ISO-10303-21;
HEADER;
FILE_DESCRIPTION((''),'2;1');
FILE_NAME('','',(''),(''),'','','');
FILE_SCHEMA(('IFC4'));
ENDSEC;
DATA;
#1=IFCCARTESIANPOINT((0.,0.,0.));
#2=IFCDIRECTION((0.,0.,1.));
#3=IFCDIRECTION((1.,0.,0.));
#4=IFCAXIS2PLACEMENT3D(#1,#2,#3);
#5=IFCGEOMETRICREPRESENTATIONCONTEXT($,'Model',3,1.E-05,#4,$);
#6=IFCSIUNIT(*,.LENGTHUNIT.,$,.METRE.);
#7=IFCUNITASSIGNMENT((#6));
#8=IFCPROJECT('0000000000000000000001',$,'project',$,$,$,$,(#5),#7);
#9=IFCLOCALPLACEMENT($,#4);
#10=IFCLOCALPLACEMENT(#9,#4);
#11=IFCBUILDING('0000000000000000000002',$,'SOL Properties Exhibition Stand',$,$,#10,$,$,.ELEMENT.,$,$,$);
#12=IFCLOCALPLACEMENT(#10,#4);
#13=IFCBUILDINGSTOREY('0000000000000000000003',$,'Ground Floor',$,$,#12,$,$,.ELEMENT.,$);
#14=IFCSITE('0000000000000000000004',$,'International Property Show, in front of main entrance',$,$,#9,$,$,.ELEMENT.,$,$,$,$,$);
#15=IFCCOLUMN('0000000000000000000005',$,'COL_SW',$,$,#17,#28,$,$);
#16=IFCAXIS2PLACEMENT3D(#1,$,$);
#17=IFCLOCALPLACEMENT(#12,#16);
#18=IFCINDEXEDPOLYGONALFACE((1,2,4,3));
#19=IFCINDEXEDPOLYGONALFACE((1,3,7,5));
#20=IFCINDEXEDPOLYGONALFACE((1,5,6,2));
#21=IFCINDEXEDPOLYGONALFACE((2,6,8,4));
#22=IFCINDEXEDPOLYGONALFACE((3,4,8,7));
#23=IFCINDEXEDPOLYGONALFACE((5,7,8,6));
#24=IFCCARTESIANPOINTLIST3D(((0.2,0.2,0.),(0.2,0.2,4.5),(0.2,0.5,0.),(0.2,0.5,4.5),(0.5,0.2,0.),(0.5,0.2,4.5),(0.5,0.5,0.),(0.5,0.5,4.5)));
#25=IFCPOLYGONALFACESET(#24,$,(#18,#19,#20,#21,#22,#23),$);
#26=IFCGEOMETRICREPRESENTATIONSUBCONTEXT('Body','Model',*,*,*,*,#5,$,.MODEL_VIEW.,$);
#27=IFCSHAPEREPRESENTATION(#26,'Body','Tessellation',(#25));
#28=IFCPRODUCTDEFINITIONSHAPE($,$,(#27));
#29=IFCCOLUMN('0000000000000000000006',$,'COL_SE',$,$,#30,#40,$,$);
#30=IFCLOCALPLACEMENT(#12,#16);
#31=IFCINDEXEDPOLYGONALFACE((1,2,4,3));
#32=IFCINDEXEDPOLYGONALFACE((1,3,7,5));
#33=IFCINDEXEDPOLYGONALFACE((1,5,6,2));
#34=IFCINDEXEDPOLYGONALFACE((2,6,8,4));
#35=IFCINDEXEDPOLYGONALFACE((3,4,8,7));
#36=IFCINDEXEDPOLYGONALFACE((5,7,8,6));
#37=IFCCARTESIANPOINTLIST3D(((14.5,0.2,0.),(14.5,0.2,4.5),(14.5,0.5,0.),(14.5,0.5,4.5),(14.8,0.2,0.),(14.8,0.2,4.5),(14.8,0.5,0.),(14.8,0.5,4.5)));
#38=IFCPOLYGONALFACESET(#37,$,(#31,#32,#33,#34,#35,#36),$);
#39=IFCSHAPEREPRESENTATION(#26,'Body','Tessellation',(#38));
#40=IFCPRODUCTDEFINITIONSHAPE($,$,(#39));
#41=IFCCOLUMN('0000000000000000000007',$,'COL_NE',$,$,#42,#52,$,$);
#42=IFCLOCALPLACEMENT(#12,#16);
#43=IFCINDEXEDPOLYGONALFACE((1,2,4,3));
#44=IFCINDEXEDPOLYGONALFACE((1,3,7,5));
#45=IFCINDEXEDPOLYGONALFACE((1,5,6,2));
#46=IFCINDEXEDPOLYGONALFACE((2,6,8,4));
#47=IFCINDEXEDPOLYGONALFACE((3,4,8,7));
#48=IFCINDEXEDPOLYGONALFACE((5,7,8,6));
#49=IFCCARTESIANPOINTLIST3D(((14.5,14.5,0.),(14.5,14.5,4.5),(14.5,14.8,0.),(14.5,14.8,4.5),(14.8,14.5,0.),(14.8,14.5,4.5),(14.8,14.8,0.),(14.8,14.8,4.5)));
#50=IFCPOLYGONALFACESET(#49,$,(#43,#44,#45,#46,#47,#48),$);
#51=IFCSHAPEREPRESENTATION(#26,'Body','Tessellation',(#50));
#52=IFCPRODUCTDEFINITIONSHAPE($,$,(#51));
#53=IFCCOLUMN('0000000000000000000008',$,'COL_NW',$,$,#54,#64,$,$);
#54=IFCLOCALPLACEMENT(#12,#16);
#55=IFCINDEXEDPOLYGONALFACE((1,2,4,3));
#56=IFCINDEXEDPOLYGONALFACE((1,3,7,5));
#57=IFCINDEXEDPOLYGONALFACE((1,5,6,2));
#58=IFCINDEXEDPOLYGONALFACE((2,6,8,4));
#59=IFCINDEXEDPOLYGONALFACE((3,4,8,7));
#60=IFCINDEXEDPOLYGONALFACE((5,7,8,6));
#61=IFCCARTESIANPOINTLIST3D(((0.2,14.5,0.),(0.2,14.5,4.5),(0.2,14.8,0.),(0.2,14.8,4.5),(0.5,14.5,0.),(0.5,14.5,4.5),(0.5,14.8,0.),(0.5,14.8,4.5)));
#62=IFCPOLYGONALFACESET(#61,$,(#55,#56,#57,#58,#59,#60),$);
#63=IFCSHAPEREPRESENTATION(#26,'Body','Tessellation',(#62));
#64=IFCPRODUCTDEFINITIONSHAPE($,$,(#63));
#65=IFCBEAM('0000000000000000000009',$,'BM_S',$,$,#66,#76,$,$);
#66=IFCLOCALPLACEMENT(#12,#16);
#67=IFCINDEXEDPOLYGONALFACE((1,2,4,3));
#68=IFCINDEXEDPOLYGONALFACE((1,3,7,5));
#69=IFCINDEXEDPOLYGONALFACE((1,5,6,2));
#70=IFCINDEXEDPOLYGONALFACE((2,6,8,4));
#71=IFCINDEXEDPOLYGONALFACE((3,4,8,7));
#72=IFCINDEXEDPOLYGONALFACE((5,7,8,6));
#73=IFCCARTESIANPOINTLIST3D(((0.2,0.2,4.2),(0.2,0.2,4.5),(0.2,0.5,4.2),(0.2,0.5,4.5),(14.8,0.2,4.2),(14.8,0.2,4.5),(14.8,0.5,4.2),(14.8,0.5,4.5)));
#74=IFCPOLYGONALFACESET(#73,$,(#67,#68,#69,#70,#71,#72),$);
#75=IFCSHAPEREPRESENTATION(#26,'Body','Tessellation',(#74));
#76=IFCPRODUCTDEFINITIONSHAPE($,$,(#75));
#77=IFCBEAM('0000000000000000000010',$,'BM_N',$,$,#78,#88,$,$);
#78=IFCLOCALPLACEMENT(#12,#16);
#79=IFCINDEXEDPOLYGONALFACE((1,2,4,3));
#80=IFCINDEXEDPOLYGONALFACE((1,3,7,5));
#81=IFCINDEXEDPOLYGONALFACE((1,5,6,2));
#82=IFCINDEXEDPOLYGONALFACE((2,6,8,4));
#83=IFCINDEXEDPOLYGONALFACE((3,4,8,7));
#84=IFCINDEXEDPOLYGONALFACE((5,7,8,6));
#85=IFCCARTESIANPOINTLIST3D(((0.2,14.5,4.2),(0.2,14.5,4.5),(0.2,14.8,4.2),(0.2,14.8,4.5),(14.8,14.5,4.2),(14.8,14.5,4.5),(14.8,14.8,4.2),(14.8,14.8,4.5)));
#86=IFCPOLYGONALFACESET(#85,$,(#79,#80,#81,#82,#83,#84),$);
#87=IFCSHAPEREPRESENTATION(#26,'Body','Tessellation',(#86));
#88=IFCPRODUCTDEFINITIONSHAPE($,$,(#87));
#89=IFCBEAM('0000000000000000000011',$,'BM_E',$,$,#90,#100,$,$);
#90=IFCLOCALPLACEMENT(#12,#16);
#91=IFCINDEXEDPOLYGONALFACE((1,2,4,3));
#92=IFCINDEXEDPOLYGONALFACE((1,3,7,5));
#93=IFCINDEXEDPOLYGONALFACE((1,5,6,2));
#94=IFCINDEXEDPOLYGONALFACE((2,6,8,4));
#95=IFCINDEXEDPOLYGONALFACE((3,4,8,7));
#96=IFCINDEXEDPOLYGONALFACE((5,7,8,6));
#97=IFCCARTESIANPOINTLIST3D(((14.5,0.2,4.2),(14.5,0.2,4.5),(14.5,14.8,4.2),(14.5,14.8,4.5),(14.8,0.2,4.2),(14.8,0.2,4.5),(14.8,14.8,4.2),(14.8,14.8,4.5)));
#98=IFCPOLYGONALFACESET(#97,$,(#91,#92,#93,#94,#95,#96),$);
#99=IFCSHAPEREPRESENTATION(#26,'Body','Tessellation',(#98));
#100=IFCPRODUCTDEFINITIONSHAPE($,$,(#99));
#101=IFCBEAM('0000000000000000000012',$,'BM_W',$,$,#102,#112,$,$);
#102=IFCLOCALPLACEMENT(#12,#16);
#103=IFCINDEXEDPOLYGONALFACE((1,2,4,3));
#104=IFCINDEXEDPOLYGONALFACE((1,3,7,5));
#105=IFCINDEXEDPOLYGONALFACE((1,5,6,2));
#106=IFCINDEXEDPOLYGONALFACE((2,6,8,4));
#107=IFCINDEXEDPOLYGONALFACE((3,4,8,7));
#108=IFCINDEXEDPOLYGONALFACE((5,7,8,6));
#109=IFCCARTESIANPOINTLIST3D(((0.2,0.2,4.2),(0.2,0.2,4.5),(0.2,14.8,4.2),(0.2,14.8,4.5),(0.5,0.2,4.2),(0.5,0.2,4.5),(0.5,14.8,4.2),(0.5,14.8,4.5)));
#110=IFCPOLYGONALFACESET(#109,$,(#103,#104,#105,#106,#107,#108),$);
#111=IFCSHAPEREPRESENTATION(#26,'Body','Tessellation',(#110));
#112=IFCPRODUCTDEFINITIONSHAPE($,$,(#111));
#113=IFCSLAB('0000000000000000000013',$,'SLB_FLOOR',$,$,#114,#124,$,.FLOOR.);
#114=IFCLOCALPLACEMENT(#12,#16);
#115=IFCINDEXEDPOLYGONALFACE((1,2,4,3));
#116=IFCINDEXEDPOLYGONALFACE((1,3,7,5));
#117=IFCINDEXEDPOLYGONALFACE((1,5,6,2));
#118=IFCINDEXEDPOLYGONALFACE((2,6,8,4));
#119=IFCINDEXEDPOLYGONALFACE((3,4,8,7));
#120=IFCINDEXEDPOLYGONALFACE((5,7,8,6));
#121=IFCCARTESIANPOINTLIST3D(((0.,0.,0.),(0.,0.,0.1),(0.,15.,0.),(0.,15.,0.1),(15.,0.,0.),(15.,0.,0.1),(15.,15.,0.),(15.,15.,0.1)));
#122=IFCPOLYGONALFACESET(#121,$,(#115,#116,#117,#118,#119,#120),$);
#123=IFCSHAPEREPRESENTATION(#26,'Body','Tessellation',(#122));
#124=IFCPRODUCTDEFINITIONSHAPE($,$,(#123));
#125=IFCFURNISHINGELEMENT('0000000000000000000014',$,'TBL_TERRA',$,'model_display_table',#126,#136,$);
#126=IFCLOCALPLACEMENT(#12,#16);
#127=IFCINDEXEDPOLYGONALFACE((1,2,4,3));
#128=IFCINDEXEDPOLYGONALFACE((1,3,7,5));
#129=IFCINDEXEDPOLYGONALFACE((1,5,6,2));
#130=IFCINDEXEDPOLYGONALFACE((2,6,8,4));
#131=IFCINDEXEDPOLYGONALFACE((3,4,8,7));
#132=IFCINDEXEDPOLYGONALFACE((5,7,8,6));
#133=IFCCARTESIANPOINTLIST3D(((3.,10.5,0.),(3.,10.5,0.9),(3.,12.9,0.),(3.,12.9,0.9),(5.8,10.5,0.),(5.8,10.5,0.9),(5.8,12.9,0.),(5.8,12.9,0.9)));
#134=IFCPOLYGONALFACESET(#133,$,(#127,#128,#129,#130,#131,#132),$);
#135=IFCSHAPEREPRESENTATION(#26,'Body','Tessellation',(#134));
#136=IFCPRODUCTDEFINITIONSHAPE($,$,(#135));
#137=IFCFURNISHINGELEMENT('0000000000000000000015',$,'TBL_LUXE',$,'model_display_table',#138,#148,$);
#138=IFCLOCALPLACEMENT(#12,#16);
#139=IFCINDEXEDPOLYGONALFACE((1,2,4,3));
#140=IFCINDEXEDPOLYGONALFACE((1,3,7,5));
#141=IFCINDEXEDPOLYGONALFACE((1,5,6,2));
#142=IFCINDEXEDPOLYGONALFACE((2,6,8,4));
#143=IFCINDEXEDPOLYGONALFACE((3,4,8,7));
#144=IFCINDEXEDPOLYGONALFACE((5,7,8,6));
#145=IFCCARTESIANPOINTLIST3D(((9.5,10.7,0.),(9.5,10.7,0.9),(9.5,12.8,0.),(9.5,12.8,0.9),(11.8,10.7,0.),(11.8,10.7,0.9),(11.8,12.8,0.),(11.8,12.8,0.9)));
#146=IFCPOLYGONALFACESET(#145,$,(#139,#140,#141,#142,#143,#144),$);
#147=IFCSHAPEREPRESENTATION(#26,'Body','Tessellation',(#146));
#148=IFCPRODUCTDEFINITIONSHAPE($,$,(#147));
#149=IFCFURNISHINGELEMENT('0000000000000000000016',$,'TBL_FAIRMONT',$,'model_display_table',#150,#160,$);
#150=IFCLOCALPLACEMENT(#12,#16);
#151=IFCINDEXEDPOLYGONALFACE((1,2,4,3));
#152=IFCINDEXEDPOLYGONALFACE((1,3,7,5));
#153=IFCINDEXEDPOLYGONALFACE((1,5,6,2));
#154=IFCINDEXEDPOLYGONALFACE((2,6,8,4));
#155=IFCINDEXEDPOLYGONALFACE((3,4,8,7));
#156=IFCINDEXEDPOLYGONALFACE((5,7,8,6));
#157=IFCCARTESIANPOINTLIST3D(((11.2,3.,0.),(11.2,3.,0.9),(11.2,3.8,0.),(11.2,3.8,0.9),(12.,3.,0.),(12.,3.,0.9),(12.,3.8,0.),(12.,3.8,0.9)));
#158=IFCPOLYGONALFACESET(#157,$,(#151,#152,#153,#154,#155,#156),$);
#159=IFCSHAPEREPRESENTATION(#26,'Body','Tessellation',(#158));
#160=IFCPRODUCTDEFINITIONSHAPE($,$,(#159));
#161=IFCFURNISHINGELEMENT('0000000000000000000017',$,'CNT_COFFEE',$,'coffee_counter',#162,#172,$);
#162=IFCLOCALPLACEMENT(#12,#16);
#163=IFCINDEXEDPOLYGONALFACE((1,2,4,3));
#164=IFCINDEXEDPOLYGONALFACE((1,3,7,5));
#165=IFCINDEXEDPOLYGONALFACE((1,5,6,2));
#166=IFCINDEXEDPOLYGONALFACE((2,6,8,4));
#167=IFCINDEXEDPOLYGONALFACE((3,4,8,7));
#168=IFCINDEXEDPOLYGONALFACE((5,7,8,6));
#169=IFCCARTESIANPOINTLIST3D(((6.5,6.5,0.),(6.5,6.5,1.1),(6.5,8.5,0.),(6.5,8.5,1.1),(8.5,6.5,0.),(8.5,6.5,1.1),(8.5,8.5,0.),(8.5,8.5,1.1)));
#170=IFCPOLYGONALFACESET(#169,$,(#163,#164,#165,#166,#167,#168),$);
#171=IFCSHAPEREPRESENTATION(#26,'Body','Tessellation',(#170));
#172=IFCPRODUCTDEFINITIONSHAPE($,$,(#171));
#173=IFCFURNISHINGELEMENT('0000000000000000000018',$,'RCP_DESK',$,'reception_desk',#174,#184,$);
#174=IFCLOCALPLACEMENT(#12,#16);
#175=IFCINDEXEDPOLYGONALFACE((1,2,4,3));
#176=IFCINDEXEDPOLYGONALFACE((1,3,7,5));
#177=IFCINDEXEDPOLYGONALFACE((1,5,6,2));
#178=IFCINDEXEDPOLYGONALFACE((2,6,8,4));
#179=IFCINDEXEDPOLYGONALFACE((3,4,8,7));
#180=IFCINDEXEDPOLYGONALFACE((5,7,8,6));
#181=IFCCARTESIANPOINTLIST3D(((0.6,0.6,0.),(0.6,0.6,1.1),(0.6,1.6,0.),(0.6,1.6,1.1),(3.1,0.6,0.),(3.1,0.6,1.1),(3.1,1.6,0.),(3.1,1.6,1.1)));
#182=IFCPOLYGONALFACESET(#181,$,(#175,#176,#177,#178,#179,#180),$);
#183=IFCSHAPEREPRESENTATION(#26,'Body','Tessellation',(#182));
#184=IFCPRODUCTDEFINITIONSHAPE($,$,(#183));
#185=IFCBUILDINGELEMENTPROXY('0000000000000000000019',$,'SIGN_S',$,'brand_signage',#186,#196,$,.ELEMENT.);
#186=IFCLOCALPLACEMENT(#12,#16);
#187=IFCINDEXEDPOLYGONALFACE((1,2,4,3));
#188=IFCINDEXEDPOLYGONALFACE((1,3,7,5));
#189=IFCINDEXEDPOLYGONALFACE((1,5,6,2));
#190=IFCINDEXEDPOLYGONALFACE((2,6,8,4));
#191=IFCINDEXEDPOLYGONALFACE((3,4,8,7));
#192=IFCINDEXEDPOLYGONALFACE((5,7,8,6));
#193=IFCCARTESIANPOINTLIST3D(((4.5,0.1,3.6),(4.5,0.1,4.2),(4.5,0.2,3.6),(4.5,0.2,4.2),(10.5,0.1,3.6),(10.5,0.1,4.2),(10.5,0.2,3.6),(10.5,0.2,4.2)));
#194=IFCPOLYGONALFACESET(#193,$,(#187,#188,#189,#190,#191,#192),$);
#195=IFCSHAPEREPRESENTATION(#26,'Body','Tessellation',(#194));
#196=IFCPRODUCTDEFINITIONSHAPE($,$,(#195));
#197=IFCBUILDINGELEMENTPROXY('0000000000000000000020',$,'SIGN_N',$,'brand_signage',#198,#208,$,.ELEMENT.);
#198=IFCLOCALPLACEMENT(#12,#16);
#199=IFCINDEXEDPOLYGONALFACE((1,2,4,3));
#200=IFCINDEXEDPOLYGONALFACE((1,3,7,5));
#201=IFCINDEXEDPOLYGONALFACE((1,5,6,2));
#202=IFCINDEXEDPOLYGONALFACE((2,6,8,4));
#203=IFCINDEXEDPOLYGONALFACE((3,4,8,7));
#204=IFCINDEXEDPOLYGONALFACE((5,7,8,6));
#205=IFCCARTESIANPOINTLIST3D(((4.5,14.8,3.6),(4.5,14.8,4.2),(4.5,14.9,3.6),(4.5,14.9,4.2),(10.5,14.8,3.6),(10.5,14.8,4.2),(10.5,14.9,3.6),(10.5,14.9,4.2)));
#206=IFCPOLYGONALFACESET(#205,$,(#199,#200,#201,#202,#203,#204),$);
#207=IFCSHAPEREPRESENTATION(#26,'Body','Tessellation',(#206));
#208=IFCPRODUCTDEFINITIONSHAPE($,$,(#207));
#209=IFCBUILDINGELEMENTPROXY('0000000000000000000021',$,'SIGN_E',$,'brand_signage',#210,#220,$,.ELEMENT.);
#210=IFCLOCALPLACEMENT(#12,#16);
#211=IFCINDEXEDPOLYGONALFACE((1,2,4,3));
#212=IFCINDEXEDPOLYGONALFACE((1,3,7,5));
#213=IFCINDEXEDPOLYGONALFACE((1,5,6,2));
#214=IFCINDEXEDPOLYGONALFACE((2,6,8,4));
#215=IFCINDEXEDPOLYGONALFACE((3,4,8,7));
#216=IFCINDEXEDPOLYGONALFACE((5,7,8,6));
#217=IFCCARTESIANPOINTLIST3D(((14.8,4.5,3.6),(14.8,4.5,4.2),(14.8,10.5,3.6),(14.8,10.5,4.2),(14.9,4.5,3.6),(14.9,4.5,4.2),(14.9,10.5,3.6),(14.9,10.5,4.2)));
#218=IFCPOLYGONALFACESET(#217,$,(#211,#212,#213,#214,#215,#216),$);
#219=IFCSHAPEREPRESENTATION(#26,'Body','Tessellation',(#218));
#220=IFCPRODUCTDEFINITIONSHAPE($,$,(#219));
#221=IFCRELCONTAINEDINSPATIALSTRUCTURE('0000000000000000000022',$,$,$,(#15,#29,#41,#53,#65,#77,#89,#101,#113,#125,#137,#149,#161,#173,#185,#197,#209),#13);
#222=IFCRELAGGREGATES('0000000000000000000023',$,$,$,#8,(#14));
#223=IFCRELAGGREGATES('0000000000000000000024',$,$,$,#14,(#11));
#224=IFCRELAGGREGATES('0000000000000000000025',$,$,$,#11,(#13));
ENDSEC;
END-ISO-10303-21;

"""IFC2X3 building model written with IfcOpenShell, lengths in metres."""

from ifc_helpers import new_model, si_unit, frame, frame_2d, origin, origin_with_axes, place, context, subcontext, project, spatial, rectangle, extrude, element, save


model = new_model("IFC2X3")

# Units and contexts
model_context = context("Model", 3, precision=1e-05, world=origin_with_axes())
body_context = subcontext(model_context, "Body", "Model", "MODEL_VIEW")
ifc_project = project(units=[si_unit("LENGTHUNIT", "METRE")], contexts=[model_context])

# Site, building, storey
site_placement = place(None, origin_with_axes())
site = spatial("IfcSite", under=ifc_project, at=site_placement, Name="International Property Show, in front of main entrance", CompositionType="ELEMENT")
building_placement = place(site_placement, origin_with_axes())
building = spatial("IfcBuilding", under=site, at=building_placement, Name="SOL Properties Exhibition Stand", CompositionType="ELEMENT")
storey_placement = place(building_placement, origin_with_axes())
storey = spatial("IfcBuildingStorey", under=building, at=storey_placement, Name="Ground Floor", CompositionType="ELEMENT")

# Columns
for number, where, z_axis, x_axis, name in (
    (1, (0.2, 0.2, 0.0), (0.0, 0.0, 1.0), (1.0, 0.0, 0.0), "COL_SW"),
    (2, (14.5, 0.2, 0.0), (0.0, 0.0, 1.0), (1.0, 0.0, 0.0), "COL_SE"),
    (3, (14.5, 14.5, 0.0), (0.0, 0.0, 1.0), (1.0, 0.0, 0.0), "COL_NE"),
    (4, (0.2, 14.5, 0.0), (0.0, 0.0, 1.0), (1.0, 0.0, 0.0), "COL_NW"),
):
    element("IfcColumn", number, at=place(storey_placement, frame(where, z_axis=z_axis, x_axis=x_axis)), inside=storey, Name=name, context=body_context, shape_type="SweptSolid", body=[
        extrude(rectangle(XDim=0.3, YDim=0.3, at=frame_2d((0.15, 0.15))), origin(), (0.0, 0.0, 1.0), 4.5),
    ])

# Beams
for number, where, z_axis, x_axis, name in (
    (5, (0.2, 0.2, 4.2), (0.0, 0.0, 1.0), (1.0, 0.0, 0.0), "BM_S"),
    (6, (0.2, 14.5, 4.2), (0.0, 0.0, 1.0), (1.0, 0.0, 0.0), "BM_N"),
):
    element("IfcBeam", number, at=place(storey_placement, frame(where, z_axis=z_axis, x_axis=x_axis)), inside=storey, Name=name, context=body_context, shape_type="SweptSolid", body=[
        extrude(rectangle(XDim=14.6, YDim=0.3, at=frame_2d((7.3, 0.15))), origin(), (0.0, 0.0, 1.0), 0.3),
    ])
for number, where, z_axis, x_axis, name in (
    (7, (14.5, 0.2, 4.2), (0.0, 0.0, 1.0), (1.0, 0.0, 0.0), "BM_E"),
    (8, (0.2, 0.2, 4.2), (0.0, 0.0, 1.0), (1.0, 0.0, 0.0), "BM_W"),
):
    element("IfcBeam", number, at=place(storey_placement, frame(where, z_axis=z_axis, x_axis=x_axis)), inside=storey, Name=name, context=body_context, shape_type="SweptSolid", body=[
        extrude(rectangle(XDim=0.3, YDim=14.6, at=frame_2d((0.15, 7.3))), origin(), (0.0, 0.0, 1.0), 0.3),
    ])

# Slab
slab_placement = place(storey_placement, origin_with_axes())
element("IfcSlab", 9, at=slab_placement, inside=storey, Name="SLB_FLOOR", PredefinedType="FLOOR", context=body_context, shape_type="SweptSolid", body=[
    extrude(rectangle(XDim=15.0, YDim=15.0, at=frame_2d((7.5, 7.5))), origin(), (0.0, 0.0, 1.0), 0.1),
])

# Furnishing elements
furnishing_1_placement = place(storey_placement, frame((3.0, 10.5, 0.0), z_axis=(0.0, 0.0, 1.0), x_axis=(1.0, 0.0, 0.0)))
element("IfcFurnishingElement", 10, at=furnishing_1_placement, inside=storey, Name="TBL_TERRA", ObjectType="model_display_table", context=body_context, shape_type="SweptSolid", body=[
    extrude(rectangle(XDim=2.8, YDim=2.4, at=frame_2d((1.4, 1.2))), origin(), (0.0, 0.0, 1.0), 0.9),
])
furnishing_2_placement = place(storey_placement, frame((9.5, 10.7, 0.0), z_axis=(0.0, 0.0, 1.0), x_axis=(1.0, 0.0, 0.0)))
element("IfcFurnishingElement", 11, at=furnishing_2_placement, inside=storey, Name="TBL_LUXE", ObjectType="model_display_table", context=body_context, shape_type="SweptSolid", body=[
    extrude(rectangle(XDim=2.3, YDim=2.1, at=frame_2d((1.15, 1.05))), origin(), (0.0, 0.0, 1.0), 0.9),
])
furnishing_3_placement = place(storey_placement, frame((11.2, 3.0, 0.0), z_axis=(0.0, 0.0, 1.0), x_axis=(1.0, 0.0, 0.0)))
element("IfcFurnishingElement", 12, at=furnishing_3_placement, inside=storey, Name="TBL_FAIRMONT", ObjectType="model_display_table", context=body_context, shape_type="SweptSolid", body=[
    extrude(rectangle(XDim=0.8, YDim=0.8, at=frame_2d((0.4, 0.4))), origin(), (0.0, 0.0, 1.0), 0.9),
])
furnishing_4_placement = place(storey_placement, frame((6.5, 6.5, 0.0), z_axis=(0.0, 0.0, 1.0), x_axis=(1.0, 0.0, 0.0)))
element("IfcFurnishingElement", 13, at=furnishing_4_placement, inside=storey, Name="CNT_COFFEE", ObjectType="coffee_counter", context=body_context, shape_type="SweptSolid", body=[
    extrude(rectangle(XDim=2.0, YDim=2.0, at=frame_2d((1.0, 1.0))), origin(), (0.0, 0.0, 1.0), 1.1),
])
furnishing_5_placement = place(storey_placement, frame((0.6, 0.6, 0.0), z_axis=(0.0, 0.0, 1.0), x_axis=(1.0, 0.0, 0.0)))
element("IfcFurnishingElement", 14, at=furnishing_5_placement, inside=storey, Name="RCP_DESK", ObjectType="reception_desk", context=body_context, shape_type="SweptSolid", body=[
    extrude(rectangle(XDim=2.5, YDim=1.0, at=frame_2d((1.25, 0.5))), origin(), (0.0, 0.0, 1.0), 1.1),
])

# Building element proxies
for number, where, z_axis, x_axis, name in (
    (15, (4.5, 0.1, 3.6), (0.0, 0.0, 1.0), (1.0, 0.0, 0.0), "SIGN_S"),
    (16, (4.5, 14.8, 3.6), (0.0, 0.0, 1.0), (1.0, 0.0, 0.0), "SIGN_N"),
):
    element("IfcBuildingElementProxy", number, at=place(storey_placement, frame(where, z_axis=z_axis, x_axis=x_axis)), inside=storey, Name=name, ObjectType="brand_signage", CompositionType="ELEMENT", context=body_context, shape_type="SweptSolid", body=[
        extrude(rectangle(XDim=6.0, YDim=0.1, at=frame_2d((3.0, 0.05))), origin(), (0.0, 0.0, 1.0), 0.6),
    ])
for number, where, z_axis, x_axis, name in (
    (17, (14.8, 4.5, 3.6), (0.0, 0.0, 1.0), (1.0, 0.0, 0.0), "SIGN_E"),
):
    element("IfcBuildingElementProxy", number, at=place(storey_placement, frame(where, z_axis=z_axis, x_axis=x_axis)), inside=storey, Name=name, ObjectType="brand_signage", CompositionType="ELEMENT", context=body_context, shape_type="SweptSolid", body=[
        extrude(rectangle(XDim=0.1, YDim=6.0, at=frame_2d((0.05, 3.0))), origin(), (0.0, 0.0, 1.0), 0.6),
    ])

save(model, "model.ifc")
